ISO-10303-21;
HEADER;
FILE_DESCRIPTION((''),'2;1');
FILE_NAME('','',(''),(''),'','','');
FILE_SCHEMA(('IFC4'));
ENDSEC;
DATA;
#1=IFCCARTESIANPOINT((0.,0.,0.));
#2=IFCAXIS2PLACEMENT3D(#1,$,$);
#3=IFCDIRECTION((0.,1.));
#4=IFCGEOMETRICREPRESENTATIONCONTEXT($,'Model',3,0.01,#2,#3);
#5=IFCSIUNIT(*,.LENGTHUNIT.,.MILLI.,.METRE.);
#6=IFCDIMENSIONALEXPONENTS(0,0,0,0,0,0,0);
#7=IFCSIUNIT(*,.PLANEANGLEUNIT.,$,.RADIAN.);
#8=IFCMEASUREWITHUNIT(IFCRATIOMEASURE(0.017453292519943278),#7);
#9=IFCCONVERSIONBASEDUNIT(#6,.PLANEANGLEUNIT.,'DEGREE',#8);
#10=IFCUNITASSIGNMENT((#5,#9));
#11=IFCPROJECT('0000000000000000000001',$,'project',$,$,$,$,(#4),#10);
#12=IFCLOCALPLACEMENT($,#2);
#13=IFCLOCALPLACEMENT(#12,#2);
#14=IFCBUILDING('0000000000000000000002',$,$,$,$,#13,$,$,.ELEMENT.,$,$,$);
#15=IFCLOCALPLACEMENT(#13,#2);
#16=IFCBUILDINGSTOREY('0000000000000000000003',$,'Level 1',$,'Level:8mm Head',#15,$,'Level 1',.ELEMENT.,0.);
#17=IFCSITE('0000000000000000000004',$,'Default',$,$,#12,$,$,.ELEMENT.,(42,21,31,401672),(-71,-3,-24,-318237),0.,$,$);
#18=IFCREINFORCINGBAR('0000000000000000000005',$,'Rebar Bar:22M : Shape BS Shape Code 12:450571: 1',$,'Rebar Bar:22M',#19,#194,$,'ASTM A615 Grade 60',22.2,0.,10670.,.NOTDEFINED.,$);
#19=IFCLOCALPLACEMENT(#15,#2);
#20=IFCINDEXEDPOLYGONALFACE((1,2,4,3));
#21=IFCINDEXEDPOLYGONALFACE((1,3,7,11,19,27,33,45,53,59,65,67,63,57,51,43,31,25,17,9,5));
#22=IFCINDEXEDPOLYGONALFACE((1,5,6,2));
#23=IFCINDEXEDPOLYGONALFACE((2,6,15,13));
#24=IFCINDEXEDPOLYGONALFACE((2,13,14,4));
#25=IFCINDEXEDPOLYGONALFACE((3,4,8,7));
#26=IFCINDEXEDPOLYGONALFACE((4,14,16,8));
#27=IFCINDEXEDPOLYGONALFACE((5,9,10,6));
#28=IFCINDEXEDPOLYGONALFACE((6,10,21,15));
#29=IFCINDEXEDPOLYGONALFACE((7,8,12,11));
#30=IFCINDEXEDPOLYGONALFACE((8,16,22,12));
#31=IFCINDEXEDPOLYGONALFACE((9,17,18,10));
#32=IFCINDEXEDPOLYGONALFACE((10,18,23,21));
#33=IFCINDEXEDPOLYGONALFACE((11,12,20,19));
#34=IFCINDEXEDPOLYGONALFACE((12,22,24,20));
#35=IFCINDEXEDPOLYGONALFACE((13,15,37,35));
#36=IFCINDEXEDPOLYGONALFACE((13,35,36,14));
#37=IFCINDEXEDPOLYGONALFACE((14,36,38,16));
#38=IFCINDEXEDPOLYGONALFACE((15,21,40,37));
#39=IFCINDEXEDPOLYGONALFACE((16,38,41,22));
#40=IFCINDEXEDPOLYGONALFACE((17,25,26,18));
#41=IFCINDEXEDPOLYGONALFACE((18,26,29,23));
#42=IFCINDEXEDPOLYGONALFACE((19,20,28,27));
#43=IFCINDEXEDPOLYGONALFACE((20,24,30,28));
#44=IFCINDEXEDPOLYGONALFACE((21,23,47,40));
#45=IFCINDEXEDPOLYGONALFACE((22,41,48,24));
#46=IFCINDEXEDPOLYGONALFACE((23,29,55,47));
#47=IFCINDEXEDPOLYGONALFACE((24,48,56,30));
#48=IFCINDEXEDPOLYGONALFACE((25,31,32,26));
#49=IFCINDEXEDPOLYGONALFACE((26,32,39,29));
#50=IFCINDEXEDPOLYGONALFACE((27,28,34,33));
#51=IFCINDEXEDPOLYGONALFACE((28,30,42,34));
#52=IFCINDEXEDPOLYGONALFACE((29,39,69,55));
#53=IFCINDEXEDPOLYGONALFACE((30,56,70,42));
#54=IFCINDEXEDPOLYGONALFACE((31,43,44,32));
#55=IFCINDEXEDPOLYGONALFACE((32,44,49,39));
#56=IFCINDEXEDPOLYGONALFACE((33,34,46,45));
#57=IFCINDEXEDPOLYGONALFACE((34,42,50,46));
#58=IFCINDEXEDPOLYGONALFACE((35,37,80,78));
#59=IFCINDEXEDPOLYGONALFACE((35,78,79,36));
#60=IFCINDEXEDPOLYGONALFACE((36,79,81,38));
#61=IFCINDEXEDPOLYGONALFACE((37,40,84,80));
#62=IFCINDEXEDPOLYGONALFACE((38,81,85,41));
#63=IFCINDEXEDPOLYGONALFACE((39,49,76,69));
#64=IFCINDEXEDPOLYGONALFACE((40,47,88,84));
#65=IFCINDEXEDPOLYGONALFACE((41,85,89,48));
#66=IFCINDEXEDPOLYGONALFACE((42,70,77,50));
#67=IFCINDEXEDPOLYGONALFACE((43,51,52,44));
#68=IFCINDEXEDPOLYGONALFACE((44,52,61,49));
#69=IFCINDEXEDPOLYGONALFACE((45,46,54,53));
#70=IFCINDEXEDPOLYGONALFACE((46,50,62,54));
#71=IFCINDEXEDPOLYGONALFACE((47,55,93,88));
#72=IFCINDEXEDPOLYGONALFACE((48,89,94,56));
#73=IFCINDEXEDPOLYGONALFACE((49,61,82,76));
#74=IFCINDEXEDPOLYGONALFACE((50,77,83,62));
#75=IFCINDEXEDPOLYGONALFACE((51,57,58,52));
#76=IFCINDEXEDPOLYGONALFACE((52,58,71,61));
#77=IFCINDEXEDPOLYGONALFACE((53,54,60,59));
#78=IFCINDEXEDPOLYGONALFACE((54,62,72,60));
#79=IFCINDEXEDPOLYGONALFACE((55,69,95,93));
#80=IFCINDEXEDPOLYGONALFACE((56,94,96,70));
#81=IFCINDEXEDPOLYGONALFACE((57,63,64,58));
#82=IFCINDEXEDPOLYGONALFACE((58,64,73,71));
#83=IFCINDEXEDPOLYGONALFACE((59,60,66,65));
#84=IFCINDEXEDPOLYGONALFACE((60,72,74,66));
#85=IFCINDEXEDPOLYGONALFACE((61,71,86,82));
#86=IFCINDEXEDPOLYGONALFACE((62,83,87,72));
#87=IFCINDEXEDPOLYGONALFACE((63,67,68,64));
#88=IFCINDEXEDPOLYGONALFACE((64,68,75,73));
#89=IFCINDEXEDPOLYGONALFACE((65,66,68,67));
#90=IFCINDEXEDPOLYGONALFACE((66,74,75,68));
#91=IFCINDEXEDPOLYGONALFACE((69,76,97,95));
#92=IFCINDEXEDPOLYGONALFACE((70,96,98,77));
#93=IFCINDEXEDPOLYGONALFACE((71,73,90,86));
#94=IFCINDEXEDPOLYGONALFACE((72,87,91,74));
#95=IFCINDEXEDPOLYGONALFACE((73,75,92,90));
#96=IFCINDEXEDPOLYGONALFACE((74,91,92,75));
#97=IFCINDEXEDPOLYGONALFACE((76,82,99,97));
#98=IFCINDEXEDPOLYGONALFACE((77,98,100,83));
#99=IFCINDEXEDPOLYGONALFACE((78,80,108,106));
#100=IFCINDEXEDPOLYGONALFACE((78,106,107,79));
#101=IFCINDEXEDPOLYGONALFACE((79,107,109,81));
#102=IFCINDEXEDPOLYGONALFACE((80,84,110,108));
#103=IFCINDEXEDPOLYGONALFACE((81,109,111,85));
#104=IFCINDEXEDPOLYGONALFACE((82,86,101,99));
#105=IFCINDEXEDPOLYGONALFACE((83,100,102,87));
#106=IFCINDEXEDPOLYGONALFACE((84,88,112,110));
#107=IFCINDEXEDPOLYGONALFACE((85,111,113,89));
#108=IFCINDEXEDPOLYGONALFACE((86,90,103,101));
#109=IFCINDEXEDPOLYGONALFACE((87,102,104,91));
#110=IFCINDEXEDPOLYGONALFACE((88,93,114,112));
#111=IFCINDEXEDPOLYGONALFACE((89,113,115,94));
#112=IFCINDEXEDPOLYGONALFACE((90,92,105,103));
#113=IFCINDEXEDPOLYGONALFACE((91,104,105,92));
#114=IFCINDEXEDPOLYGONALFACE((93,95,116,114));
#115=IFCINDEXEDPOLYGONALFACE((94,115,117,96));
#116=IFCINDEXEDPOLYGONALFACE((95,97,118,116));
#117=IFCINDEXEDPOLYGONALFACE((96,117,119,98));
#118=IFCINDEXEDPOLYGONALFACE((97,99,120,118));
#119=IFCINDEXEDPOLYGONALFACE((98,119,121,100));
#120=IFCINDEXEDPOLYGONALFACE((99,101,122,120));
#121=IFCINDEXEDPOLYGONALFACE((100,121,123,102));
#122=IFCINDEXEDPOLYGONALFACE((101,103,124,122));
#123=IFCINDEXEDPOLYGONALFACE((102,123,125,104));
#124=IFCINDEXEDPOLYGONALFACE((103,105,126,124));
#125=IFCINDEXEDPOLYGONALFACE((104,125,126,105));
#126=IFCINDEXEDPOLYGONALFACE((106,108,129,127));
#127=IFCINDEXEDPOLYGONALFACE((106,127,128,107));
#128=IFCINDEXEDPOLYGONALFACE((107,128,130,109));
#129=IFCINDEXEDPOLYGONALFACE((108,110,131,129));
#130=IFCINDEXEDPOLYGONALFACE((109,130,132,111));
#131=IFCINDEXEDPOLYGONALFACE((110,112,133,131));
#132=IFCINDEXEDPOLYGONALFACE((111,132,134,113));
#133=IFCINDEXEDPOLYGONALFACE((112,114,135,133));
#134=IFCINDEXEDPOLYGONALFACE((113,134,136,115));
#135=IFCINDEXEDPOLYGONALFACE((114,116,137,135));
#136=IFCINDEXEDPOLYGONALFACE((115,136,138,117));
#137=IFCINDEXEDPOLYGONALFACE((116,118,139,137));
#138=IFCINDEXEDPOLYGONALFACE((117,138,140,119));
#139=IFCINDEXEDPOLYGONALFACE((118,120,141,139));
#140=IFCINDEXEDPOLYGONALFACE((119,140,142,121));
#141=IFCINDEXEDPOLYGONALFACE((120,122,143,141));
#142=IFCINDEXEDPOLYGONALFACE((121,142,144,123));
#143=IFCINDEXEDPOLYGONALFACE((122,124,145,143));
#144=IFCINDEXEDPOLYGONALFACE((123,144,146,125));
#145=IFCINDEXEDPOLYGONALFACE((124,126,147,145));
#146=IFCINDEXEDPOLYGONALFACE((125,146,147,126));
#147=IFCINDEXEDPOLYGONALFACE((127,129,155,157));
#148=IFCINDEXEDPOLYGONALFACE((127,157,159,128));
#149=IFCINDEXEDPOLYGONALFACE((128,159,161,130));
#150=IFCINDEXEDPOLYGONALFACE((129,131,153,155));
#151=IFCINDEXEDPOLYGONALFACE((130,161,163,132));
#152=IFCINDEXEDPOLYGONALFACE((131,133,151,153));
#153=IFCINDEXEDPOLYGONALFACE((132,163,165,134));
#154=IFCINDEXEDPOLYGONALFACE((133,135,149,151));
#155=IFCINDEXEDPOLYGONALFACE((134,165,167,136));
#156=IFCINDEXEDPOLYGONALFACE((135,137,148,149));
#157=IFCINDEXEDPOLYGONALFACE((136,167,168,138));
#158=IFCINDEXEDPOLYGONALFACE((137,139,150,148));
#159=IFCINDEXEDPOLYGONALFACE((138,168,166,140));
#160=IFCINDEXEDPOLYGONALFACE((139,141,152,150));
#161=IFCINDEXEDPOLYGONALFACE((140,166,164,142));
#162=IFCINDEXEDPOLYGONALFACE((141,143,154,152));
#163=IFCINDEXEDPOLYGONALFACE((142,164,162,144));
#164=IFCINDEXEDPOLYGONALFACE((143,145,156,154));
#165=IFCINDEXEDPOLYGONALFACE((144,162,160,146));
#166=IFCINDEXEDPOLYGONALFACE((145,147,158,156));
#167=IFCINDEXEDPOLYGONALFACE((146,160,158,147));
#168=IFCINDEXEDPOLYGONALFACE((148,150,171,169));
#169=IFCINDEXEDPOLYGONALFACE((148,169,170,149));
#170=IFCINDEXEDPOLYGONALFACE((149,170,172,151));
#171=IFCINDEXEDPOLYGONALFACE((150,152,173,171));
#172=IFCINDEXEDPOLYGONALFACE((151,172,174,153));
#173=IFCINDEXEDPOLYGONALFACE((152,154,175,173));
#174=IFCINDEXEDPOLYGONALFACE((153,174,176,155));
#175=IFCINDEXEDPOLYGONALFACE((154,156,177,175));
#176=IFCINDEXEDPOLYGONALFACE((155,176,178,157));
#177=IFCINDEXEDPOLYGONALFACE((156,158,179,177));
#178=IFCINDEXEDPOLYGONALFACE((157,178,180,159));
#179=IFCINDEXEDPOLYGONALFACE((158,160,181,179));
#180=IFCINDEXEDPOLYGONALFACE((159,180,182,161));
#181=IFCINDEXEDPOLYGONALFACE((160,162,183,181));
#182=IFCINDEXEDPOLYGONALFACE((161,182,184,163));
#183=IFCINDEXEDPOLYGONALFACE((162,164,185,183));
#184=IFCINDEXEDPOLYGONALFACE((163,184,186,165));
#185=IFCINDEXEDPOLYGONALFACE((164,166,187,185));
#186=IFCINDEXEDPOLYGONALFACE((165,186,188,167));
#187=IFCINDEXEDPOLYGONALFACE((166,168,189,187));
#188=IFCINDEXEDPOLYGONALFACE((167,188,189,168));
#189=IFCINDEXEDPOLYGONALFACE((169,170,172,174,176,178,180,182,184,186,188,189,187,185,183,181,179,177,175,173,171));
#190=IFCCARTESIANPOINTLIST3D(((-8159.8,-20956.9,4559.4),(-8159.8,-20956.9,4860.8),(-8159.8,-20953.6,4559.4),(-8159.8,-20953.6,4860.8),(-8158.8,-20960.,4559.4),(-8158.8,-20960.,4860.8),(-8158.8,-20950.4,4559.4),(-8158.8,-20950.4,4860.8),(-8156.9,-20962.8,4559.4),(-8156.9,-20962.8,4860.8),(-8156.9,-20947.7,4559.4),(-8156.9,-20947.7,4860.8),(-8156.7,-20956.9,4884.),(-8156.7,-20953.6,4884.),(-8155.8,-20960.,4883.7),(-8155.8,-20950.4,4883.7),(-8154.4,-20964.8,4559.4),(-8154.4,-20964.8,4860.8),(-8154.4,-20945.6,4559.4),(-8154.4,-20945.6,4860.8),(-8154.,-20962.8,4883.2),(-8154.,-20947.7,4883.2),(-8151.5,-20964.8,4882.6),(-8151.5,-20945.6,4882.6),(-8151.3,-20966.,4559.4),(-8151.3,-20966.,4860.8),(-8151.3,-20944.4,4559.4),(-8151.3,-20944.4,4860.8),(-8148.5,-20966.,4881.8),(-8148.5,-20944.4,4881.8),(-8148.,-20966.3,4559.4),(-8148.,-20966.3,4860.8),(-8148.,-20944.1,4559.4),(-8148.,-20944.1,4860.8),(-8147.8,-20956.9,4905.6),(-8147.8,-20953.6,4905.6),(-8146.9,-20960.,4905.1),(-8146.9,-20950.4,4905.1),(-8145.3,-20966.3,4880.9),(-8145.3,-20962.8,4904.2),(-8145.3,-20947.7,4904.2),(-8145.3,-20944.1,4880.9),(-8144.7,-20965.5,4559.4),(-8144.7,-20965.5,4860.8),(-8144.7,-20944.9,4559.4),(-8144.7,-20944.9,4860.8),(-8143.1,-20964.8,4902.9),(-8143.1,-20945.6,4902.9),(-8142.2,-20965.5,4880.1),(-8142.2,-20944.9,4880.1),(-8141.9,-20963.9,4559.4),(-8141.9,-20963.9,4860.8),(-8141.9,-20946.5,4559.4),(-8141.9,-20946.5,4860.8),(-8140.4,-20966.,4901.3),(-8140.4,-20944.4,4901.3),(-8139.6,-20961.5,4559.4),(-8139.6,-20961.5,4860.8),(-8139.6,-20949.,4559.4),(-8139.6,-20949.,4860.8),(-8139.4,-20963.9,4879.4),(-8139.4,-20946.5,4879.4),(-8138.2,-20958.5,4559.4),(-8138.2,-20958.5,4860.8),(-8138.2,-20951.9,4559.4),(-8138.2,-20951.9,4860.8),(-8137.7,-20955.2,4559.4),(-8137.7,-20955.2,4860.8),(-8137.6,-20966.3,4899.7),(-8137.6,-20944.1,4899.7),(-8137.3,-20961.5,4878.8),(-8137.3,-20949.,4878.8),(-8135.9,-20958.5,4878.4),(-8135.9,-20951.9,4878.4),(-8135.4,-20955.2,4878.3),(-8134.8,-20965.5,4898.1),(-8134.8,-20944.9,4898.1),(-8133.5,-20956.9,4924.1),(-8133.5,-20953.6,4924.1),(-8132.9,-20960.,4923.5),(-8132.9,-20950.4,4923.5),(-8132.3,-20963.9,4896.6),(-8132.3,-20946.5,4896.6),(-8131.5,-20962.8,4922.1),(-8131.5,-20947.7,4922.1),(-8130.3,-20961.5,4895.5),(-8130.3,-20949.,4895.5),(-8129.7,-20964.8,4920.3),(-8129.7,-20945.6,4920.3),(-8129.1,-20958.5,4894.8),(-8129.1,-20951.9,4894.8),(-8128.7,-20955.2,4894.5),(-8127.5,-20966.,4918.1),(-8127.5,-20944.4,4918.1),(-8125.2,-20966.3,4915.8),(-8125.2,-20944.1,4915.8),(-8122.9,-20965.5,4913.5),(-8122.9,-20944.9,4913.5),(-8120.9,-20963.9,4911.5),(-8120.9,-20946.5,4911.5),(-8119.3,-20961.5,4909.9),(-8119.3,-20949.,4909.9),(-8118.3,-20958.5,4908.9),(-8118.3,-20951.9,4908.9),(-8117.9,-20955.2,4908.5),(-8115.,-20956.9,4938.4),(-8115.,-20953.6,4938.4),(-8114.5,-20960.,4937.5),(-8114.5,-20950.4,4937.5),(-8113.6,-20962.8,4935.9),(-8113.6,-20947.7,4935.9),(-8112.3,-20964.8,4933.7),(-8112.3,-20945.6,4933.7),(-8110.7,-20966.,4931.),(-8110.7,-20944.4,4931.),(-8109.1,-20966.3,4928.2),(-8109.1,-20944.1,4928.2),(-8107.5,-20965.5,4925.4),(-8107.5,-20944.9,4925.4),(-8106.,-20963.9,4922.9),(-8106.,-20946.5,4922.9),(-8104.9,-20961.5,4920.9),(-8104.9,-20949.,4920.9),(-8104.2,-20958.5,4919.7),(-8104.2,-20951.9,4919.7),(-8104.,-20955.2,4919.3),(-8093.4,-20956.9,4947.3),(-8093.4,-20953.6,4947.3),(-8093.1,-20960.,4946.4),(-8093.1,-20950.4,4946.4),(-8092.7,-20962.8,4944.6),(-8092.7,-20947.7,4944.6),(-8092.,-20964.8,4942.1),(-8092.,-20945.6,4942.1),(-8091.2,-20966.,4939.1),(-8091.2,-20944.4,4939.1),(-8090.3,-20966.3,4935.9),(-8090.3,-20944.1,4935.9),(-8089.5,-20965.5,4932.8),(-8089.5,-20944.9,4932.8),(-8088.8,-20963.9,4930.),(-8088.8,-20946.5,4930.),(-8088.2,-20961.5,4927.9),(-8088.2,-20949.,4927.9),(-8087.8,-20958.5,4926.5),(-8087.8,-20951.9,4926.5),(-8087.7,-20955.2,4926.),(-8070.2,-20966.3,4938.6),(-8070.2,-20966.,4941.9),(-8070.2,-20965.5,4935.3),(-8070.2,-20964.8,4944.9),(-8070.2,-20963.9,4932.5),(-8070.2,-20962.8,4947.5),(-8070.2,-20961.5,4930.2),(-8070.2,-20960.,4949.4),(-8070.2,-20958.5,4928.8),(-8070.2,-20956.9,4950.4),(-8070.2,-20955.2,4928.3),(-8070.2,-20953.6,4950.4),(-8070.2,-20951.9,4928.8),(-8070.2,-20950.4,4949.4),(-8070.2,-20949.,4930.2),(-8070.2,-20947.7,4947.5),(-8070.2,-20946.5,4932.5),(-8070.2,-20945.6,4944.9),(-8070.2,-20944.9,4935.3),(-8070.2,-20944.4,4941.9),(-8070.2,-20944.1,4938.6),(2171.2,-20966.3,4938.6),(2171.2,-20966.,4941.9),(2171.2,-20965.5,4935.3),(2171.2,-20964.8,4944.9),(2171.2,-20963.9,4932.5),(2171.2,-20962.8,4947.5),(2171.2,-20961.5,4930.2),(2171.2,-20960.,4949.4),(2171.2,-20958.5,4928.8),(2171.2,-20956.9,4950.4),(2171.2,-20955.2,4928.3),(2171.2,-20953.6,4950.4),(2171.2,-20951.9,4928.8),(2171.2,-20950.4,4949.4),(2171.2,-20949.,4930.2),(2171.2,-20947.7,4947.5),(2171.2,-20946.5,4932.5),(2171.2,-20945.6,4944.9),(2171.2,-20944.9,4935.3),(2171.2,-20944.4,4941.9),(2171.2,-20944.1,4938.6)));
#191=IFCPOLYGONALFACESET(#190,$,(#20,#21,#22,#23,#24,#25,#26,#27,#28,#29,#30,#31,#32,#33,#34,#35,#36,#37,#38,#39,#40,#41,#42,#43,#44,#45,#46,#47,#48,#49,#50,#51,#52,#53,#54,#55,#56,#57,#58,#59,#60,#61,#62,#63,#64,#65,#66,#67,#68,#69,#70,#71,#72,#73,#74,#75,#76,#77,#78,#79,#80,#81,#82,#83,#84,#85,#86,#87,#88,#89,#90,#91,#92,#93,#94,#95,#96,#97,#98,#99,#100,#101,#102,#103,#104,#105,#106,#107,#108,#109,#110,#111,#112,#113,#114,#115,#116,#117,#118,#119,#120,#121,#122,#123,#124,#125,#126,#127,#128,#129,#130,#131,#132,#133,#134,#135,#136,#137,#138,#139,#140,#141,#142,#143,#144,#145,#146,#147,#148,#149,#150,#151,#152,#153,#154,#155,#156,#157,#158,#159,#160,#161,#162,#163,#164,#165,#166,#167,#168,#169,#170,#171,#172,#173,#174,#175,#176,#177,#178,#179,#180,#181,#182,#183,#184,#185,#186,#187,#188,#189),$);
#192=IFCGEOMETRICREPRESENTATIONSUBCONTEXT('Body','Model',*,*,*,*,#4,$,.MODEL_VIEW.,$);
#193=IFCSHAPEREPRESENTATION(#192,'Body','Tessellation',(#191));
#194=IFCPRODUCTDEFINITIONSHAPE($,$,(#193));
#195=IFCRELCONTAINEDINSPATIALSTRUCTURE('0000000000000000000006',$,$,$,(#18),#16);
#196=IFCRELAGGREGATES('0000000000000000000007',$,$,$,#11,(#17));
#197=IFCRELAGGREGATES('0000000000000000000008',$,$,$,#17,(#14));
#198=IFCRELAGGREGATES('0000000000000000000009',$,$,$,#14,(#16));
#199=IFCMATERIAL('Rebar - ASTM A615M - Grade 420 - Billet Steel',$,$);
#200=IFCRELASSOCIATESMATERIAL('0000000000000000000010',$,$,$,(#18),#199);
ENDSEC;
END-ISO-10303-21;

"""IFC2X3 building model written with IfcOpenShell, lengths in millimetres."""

from ifc_helpers import new_model, entity, si_unit, converted_unit, direction, origin, place, context, subcontext, project, spatial, material, element, save


model = new_model("IFC2X3")

# Units and contexts
model_context = context("Model", 3, precision=0.01, world=origin(), true_north=direction((0.0, 1.0)))
body_context = subcontext(model_context, "Body", "Model", "MODEL_VIEW")
ifc_project = project(units=[si_unit("LENGTHUNIT", "METRE", prefix="MILLI"), converted_unit("PLANEANGLEUNIT", "DEGREE", entity("IfcRatioMeasure", 0.017453292519943278), si_unit("PLANEANGLEUNIT", "RADIAN"), dimensions=[0, 0, 0, 0, 0, 0, 0])], contexts=[model_context])

# Site, building, storey
site_placement = place(None, origin())
site = spatial("IfcSite", under=ifc_project, at=site_placement, Name="Default", CompositionType="ELEMENT", RefLatitude=(42, 21, 31, 401672), RefLongitude=(-71, -3, -24, -318237), RefElevation=0.0)
building_placement = place(site_placement, origin())
building = spatial("IfcBuilding", under=site, at=building_placement, CompositionType="ELEMENT")
storey_placement = place(building_placement, origin())
storey = spatial("IfcBuildingStorey", under=building, at=storey_placement, Name="Level 1", ObjectType="Level:8mm Head", LongName="Level 1", CompositionType="ELEMENT", Elevation=0.0)

# Reinforcing bar
ifc_material = material(Name="Rebar - ASTM A615M - Grade 420 - Billet Steel")
reinforcing_bar_1_placement = place(storey_placement, origin())
element("IfcReinforcingBar", 1, at=reinforcing_bar_1_placement, inside=storey, material=ifc_material, Name="Rebar Bar:22M : Shape BS Shape Code 12:450571: 1", SteelGrade="ASTM A615 Grade 60", ObjectType="Rebar Bar:22M", BarLength=10670.0, BarRole="NOTDEFINED", CrossSectionArea=0.0, NominalDiameter=22.2, context=body_context, shape_type="AdvancedSweptSolid", body=[
    entity("IfcSweptDiskSolid", entity("IfcCompositeCurve", [entity("IfcCompositeCurveSegment", "CONTINUOUS", True, entity("IfcPolyline", [entity("IfcCartesianPoint", [2171.2, -20955.2, 4939.4]), entity("IfcCartesianPoint", [-8070.2, -20955.2, 4939.4])])), entity("IfcCompositeCurveSegment", "CONTINUOUS", True, entity("IfcTrimmedCurve", entity("IfcCircle", entity("IfcAxis2Placement3D", entity("IfcCartesianPoint", [-8070.2, -20955.2, 4860.8]), entity("IfcDirection", [0.0, -1.0, 0.0]), entity("IfcDirection", [-1.0, 0.0, 0.0])), 78.6), [entity("IfcParameterValue", 270.0)], [entity("IfcParameterValue", 360.0)], True, "PARAMETER")), entity("IfcCompositeCurveSegment", "CONTINUOUS", True, entity("IfcPolyline", [entity("IfcCartesianPoint", [-8148.8, -20955.2, 4860.8]), entity("IfcCartesianPoint", [-8148.8, -20955.2, 4559.4])]))], False), 11.1, None, 0.0, 92.0),
])

save(model, "model.ifc")
